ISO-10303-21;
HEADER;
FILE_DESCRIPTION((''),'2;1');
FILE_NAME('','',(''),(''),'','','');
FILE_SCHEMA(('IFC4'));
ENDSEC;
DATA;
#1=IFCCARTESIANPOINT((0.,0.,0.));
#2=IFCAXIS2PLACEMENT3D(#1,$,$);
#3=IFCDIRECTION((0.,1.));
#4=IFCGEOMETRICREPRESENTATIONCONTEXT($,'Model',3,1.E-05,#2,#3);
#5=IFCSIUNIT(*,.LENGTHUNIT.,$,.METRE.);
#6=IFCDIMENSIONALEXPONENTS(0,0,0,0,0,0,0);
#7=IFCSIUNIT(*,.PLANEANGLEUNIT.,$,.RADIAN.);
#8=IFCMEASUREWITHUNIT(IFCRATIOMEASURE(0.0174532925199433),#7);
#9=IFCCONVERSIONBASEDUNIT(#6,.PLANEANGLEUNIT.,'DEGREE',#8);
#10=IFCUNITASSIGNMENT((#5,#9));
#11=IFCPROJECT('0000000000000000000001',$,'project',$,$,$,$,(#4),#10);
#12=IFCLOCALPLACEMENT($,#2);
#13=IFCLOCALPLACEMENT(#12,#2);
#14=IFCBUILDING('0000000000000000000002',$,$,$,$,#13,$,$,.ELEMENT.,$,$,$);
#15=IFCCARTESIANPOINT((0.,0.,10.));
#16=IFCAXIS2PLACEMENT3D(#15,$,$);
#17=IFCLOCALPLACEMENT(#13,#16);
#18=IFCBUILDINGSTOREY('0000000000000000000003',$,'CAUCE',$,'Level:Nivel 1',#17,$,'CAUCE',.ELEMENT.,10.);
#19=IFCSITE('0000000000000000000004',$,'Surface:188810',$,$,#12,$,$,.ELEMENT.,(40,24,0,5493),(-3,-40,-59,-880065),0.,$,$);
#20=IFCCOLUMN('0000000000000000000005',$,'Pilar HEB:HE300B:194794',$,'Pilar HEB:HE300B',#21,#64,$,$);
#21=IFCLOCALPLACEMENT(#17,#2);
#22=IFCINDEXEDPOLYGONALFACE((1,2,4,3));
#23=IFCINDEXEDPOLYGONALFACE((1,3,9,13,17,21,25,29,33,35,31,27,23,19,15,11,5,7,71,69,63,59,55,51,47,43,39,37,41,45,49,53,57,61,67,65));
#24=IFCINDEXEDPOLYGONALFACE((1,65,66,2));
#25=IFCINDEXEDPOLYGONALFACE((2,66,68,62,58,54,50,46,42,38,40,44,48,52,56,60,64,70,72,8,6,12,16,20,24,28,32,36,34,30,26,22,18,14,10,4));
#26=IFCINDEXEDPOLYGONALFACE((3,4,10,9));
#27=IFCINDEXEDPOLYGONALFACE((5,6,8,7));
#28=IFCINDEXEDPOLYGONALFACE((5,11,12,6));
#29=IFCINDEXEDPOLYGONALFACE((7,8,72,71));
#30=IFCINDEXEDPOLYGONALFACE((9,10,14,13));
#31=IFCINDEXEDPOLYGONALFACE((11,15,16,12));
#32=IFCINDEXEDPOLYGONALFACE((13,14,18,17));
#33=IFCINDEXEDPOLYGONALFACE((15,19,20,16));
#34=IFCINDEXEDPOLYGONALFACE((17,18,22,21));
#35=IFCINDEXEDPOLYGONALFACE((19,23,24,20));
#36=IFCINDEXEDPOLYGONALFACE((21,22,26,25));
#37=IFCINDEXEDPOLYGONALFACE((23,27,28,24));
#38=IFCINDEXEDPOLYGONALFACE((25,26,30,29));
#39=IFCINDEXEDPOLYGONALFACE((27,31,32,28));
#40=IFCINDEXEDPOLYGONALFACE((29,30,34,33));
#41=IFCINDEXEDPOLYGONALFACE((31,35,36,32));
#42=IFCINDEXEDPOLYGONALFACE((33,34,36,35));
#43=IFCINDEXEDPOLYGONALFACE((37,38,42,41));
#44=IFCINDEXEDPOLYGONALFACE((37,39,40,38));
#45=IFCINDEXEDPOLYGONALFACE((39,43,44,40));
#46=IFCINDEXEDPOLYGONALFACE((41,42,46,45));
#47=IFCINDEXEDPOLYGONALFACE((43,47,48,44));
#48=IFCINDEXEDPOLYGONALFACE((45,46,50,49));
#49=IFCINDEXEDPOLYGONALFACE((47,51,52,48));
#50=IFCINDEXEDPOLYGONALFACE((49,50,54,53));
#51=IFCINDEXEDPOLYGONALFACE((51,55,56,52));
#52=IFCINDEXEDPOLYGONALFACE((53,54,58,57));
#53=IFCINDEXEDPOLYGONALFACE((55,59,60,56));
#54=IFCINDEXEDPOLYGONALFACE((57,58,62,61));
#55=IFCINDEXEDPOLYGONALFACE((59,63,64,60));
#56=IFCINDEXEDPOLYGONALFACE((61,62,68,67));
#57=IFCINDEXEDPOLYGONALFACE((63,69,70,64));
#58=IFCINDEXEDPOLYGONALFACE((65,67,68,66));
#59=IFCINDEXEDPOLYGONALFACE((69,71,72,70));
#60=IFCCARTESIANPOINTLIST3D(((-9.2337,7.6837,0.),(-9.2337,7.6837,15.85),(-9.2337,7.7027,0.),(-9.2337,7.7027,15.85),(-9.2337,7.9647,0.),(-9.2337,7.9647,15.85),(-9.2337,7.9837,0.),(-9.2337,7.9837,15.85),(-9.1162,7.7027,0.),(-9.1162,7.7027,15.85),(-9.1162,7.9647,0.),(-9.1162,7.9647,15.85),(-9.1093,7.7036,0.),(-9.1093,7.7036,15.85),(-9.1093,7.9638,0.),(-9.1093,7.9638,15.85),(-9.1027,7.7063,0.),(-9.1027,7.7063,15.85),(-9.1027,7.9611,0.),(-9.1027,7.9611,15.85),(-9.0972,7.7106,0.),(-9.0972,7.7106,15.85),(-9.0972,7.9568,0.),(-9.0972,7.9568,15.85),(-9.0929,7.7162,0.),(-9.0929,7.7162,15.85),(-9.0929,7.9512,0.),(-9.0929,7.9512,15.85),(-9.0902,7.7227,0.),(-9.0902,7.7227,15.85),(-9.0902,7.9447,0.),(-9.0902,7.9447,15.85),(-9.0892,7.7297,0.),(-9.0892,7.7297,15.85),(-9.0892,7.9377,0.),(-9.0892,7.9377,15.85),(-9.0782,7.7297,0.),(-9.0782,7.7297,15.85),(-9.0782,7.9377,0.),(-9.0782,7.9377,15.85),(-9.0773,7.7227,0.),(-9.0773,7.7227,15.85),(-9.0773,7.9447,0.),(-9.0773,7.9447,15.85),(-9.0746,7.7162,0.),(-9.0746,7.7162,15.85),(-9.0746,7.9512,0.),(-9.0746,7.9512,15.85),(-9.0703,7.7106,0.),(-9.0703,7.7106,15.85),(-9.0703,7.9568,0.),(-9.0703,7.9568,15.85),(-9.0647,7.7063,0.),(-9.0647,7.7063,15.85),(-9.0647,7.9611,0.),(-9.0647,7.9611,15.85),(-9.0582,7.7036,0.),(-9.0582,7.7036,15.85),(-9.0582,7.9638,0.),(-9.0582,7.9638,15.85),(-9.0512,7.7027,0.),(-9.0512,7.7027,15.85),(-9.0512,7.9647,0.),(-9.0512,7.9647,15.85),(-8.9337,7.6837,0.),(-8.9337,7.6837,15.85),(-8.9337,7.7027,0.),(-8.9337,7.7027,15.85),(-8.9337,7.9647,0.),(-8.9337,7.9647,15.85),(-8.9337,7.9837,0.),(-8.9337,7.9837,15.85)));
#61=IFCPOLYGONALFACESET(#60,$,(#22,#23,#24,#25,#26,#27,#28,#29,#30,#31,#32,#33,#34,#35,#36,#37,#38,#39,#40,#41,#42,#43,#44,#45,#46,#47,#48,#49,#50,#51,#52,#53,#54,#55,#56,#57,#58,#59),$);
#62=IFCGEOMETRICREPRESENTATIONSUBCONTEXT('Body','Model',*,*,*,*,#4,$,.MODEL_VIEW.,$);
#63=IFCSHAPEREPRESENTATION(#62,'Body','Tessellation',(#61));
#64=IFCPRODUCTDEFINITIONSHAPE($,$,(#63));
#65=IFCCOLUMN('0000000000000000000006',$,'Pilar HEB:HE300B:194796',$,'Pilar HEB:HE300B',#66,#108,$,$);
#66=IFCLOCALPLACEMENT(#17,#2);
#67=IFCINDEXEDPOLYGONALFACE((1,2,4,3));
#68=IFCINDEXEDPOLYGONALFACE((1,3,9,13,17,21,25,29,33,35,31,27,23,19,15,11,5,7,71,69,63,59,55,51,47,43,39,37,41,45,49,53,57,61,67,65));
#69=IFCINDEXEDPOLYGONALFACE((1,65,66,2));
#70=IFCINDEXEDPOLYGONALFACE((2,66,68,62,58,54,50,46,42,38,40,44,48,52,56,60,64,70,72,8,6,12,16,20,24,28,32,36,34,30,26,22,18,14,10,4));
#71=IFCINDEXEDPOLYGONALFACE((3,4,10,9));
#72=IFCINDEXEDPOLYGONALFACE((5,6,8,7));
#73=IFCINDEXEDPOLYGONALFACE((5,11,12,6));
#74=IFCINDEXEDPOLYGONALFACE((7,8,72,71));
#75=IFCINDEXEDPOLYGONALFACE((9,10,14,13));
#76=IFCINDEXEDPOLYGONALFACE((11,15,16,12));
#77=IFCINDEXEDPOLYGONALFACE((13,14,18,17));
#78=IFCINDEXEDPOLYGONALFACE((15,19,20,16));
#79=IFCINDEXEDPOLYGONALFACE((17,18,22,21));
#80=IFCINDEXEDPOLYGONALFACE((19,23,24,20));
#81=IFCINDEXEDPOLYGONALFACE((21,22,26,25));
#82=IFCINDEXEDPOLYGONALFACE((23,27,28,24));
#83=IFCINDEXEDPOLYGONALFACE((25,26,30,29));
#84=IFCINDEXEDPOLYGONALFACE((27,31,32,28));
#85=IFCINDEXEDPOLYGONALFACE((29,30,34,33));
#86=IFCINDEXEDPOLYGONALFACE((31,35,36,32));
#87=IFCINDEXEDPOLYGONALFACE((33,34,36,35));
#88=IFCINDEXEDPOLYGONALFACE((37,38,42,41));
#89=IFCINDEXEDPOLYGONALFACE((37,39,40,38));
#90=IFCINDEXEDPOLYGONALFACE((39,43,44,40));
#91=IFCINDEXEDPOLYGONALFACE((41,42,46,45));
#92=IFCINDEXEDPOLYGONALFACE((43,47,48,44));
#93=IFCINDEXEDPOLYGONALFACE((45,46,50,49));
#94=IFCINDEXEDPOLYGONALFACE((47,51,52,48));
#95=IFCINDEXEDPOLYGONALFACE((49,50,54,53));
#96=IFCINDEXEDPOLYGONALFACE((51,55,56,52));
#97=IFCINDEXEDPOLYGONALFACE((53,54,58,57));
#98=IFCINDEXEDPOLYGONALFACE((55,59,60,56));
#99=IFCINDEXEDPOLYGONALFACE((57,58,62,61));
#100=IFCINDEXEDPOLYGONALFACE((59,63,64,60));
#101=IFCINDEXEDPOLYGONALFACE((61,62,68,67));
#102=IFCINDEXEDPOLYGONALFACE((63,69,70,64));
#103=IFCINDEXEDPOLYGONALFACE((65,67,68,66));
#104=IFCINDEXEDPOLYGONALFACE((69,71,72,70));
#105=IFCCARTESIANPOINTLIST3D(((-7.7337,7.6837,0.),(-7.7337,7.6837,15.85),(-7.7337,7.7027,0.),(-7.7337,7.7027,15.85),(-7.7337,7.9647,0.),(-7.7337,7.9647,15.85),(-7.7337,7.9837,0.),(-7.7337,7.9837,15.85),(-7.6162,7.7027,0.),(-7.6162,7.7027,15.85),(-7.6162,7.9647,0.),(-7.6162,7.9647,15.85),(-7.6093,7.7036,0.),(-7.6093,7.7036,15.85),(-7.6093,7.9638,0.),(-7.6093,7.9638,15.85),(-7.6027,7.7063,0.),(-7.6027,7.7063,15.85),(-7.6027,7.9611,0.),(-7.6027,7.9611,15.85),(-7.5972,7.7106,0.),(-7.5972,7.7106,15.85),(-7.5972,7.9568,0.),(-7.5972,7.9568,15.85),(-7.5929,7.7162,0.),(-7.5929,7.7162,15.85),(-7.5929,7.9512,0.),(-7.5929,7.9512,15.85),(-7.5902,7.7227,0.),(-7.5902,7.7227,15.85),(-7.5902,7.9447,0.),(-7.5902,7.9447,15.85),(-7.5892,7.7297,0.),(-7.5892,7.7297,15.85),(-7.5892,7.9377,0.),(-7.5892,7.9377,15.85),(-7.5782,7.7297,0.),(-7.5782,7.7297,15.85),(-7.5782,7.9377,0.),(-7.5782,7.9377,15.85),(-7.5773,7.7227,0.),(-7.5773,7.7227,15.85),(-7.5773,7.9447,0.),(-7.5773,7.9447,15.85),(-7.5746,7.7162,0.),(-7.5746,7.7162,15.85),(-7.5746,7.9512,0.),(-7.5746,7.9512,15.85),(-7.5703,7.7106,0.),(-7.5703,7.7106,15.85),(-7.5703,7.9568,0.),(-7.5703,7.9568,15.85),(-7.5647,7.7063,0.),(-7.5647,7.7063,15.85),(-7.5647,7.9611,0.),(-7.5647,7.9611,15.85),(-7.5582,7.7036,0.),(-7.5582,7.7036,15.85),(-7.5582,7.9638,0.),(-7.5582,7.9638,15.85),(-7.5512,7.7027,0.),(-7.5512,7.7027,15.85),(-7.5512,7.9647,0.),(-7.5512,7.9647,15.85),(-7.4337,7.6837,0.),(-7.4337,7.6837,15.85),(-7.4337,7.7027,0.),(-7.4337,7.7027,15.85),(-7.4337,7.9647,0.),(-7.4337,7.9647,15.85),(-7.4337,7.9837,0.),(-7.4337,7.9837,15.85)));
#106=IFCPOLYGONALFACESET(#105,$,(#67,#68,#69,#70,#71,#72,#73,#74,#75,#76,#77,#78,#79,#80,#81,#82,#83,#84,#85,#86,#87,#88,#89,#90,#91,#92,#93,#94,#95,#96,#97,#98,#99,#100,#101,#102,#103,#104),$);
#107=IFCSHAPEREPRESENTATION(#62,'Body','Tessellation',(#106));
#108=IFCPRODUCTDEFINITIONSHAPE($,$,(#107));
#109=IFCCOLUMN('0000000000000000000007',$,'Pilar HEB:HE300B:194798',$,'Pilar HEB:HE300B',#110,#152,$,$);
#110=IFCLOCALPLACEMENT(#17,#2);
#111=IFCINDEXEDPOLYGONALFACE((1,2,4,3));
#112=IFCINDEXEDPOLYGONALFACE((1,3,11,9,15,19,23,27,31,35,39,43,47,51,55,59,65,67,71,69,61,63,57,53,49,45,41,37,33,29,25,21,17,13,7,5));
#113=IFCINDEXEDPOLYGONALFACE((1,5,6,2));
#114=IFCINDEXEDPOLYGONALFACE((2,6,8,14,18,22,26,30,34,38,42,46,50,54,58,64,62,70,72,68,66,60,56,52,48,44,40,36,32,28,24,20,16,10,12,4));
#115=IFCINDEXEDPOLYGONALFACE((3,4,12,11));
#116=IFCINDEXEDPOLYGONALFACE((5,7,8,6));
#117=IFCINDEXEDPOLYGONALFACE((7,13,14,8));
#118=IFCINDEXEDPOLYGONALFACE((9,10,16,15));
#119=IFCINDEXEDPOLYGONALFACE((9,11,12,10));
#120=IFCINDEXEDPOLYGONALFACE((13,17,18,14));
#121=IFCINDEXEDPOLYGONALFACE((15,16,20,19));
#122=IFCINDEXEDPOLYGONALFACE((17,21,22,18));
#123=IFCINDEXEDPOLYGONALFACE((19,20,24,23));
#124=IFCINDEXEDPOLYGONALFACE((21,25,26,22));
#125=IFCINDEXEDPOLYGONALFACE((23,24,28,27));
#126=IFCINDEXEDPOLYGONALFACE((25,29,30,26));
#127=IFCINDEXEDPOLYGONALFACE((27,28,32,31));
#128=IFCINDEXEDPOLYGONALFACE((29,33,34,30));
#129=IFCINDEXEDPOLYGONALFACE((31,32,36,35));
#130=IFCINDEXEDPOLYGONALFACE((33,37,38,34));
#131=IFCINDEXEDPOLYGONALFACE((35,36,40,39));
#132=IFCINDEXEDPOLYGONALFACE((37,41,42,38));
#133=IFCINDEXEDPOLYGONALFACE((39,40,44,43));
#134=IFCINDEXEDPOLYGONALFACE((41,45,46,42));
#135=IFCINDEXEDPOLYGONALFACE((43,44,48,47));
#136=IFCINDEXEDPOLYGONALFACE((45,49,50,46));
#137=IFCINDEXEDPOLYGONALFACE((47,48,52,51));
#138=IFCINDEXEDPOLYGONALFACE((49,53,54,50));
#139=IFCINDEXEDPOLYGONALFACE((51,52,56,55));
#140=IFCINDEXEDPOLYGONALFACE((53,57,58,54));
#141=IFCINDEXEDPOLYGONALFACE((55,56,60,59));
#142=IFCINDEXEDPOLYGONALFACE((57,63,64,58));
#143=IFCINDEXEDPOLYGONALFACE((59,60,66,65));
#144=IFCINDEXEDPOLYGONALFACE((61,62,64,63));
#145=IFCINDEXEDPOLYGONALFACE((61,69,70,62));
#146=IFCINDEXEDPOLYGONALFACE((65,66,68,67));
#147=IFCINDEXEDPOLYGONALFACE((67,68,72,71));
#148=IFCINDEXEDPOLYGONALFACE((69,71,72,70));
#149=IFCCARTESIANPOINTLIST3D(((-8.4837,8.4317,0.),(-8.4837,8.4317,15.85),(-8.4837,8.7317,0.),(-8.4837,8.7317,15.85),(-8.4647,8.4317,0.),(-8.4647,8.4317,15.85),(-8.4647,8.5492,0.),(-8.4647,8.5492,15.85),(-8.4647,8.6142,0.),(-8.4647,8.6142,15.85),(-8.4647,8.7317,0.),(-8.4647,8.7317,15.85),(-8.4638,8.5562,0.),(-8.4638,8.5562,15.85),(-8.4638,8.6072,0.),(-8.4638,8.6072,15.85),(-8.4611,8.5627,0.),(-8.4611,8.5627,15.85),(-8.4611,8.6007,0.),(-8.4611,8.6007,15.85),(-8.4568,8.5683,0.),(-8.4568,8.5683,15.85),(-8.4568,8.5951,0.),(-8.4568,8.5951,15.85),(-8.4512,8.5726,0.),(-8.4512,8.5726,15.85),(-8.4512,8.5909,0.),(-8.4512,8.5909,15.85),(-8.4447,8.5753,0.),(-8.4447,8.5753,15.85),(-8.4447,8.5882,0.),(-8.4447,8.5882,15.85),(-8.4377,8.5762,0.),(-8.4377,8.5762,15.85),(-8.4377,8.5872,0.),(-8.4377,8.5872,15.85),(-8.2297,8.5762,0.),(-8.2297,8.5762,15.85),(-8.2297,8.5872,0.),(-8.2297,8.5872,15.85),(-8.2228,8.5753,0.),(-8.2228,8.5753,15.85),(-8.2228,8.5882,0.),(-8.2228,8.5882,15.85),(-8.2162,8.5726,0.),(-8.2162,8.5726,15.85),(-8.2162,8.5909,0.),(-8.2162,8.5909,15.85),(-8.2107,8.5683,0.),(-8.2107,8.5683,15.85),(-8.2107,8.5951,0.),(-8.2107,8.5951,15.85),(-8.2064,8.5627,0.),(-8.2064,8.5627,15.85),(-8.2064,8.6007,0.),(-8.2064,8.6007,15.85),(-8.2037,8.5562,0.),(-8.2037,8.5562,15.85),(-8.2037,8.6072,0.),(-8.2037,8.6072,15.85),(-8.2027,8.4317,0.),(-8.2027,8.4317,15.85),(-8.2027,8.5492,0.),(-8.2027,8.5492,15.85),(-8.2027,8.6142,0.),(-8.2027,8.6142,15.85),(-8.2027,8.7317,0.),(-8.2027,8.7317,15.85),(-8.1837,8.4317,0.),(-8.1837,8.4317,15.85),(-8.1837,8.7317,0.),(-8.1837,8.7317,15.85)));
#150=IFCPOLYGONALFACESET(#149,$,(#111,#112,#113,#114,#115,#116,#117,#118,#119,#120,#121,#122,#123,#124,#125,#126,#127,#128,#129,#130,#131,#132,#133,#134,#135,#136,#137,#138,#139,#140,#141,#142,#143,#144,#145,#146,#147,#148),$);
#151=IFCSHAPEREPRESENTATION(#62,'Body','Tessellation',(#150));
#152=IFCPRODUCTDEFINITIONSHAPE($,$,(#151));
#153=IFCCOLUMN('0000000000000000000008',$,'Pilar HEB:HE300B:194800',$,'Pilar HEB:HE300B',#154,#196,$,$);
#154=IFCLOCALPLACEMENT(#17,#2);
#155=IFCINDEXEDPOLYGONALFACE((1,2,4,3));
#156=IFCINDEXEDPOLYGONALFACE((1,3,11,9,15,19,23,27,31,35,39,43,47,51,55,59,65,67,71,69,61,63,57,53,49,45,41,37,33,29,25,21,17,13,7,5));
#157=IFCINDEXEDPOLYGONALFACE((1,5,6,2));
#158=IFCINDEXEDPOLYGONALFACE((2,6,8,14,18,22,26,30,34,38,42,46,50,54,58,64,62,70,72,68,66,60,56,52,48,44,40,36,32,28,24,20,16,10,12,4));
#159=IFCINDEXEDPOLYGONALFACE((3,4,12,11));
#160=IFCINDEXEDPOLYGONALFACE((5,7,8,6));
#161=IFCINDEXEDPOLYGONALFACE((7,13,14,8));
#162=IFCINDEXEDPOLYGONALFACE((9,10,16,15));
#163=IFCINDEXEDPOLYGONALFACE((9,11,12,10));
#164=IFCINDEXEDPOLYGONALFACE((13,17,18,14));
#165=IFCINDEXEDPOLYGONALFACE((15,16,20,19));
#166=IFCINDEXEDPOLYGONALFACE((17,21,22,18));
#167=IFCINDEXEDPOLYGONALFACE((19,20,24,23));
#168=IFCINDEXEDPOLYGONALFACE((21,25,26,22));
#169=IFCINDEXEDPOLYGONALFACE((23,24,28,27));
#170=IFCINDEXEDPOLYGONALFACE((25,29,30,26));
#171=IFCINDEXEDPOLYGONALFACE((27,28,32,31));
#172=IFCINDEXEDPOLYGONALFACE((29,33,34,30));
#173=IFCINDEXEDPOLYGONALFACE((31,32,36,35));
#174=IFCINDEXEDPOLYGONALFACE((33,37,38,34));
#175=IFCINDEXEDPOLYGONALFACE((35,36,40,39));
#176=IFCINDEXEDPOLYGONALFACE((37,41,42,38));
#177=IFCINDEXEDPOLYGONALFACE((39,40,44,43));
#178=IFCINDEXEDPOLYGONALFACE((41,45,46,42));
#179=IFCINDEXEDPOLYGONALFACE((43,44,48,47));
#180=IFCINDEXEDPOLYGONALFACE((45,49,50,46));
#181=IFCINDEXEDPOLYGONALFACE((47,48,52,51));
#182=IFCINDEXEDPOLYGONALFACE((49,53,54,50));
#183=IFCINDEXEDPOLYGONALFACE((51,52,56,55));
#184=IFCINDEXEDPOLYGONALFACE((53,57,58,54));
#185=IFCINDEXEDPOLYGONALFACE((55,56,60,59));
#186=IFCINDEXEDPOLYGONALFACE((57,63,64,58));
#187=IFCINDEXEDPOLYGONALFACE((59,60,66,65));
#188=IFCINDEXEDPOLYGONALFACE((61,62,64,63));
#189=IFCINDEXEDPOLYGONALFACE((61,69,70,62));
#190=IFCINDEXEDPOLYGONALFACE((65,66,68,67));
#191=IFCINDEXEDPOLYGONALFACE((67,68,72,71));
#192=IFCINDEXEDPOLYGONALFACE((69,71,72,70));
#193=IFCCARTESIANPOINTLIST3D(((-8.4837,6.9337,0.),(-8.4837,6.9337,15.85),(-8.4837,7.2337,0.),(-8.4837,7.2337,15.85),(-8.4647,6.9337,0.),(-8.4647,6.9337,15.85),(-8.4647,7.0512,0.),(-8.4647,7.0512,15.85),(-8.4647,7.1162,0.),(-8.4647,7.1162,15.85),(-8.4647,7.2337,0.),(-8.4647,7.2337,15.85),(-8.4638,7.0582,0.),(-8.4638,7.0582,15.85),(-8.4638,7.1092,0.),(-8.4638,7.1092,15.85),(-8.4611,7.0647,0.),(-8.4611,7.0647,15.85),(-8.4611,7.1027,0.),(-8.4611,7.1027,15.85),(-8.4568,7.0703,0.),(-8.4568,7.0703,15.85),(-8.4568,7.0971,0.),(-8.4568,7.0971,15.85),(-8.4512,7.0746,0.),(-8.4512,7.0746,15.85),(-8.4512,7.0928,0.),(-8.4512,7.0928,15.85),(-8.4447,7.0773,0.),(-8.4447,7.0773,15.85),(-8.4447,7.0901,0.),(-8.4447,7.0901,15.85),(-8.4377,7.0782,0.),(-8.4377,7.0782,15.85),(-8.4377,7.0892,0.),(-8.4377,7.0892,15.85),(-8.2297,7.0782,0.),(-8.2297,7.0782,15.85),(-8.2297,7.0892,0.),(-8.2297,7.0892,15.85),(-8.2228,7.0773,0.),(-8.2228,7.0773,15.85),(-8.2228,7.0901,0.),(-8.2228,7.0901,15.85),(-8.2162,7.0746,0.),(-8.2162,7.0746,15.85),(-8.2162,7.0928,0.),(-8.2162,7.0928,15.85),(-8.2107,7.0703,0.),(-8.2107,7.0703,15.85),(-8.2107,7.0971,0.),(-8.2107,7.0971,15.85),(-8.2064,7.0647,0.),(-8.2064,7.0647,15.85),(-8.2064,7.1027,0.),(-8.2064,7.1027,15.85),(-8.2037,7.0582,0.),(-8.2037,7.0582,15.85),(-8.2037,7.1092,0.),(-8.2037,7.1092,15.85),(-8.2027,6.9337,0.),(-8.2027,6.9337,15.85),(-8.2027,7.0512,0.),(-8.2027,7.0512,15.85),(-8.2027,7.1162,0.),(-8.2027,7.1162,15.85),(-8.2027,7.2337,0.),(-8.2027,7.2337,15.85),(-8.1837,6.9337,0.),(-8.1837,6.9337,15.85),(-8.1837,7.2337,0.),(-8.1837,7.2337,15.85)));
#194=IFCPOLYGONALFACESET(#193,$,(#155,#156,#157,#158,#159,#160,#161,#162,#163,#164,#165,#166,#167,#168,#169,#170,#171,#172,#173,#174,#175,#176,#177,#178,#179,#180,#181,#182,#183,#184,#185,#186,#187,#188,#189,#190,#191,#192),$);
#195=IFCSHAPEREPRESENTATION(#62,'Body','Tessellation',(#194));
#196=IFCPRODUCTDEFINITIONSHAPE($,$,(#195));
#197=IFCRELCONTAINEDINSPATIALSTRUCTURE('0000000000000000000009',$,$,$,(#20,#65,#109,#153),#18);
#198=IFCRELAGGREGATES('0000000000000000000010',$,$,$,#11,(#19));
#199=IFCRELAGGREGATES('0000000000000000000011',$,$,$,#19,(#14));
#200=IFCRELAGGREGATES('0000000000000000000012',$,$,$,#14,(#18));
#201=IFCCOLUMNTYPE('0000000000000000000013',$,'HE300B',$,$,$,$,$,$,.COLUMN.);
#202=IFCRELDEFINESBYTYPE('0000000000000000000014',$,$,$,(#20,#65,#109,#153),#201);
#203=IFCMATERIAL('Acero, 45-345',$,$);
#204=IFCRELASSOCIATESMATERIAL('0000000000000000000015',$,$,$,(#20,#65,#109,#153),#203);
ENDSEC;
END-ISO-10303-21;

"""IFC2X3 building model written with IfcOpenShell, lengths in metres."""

from ifc_helpers import new_model, entity, si_unit, converted_unit, direction, frame, frame_2d, origin, place, context, subcontext, project, spatial, i_section, extrude, source, transform, mapped, material, type_object, type_shapes, element, save


model = new_model("IFC2X3")

# Units and contexts
model_context = context("Model", 3, precision=1e-05, world=origin(), true_north=direction((0.0, 1.0)))
body_context = subcontext(model_context, "Body", "Model", "MODEL_VIEW")
ifc_project = project(units=[si_unit("LENGTHUNIT", "METRE"), converted_unit("PLANEANGLEUNIT", "DEGREE", entity("IfcRatioMeasure", 0.0174532925199433), si_unit("PLANEANGLEUNIT", "RADIAN"), dimensions=[0, 0, 0, 0, 0, 0, 0])], contexts=[model_context])

# Site, building, storey
site_placement = place(None, origin())
site = spatial("IfcSite", under=ifc_project, at=site_placement, Name="Surface:188810", CompositionType="ELEMENT", RefLatitude=(40, 24, 0, 5493), RefLongitude=(-3, -40, -59, -880065), RefElevation=0.0)
building_placement = place(site_placement, origin())
building = spatial("IfcBuilding", under=site, at=building_placement, CompositionType="ELEMENT")
storey_placement = place(building_placement, frame((0.0, 0.0, 10.0)))
storey = spatial("IfcBuildingStorey", under=building, at=storey_placement, Name="CAUCE", ObjectType="Level:Nivel 1", LongName="CAUCE", CompositionType="ELEMENT", Elevation=10.0)

# Columns
ifc_material_1 = material(Name="Acero, 45-345")
column_type_1 = type_object("IfcColumnType", Name="HE300B", PredefinedType="COLUMN")
shared_shape_1 = source(origin(), body_context, "Body", "SweptSolid", [
    extrude(i_section(OverallWidth=0.3, OverallDepth=0.3, WebThickness=0.011, FlangeThickness=0.019, FilletRadius=0.027, at=frame_2d((0.0, 0.0), x_axis=(0.0, 1.0))), frame((0.0, 0.0, 10.0), z_axis=(0.0, 0.0, 1.0), x_axis=(0.0, -1.0, 0.0)), (0.0, 0.0, 1.0), 15.85),
])
type_shapes(column_type_1, [shared_shape_1])
for number, where, name in (
    (1, (-9.0837, 7.8337, -10.0), "Pilar HEB:HE300B:194794"),
    (2, (-7.5837, 7.8337, -10.0), "Pilar HEB:HE300B:194796"),
):
    element("IfcColumn", number, at=place(storey_placement, frame(where)), inside=storey, type_object=column_type_1, material=ifc_material_1, Name=name, ObjectType="Pilar HEB:HE300B", context=body_context, shape_type="MappedRepresentation", body=[
        mapped(shared_shape_1, transform((0.0, 0.0, 0.0), scale=1.0)),
    ])
for number, where, z_axis, x_axis, name in (
    (3, (-8.3337, 8.5817, -10.0), (0.0, 0.0, 1.0), (0.0, 1.0, 0.0), "Pilar HEB:HE300B:194798"),
    (4, (-8.3337, 7.0837, -10.0), (0.0, 0.0, 1.0), (0.0, 1.0, 0.0), "Pilar HEB:HE300B:194800"),
):
    element("IfcColumn", number, at=place(storey_placement, frame(where, z_axis=z_axis, x_axis=x_axis)), inside=storey, type_object=column_type_1, material=ifc_material_1, Name=name, ObjectType="Pilar HEB:HE300B", context=body_context, shape_type="MappedRepresentation", body=[
        mapped(shared_shape_1, transform((0.0, 0.0, 0.0), scale=1.0)),
    ])

save(model, "model.ifc")
